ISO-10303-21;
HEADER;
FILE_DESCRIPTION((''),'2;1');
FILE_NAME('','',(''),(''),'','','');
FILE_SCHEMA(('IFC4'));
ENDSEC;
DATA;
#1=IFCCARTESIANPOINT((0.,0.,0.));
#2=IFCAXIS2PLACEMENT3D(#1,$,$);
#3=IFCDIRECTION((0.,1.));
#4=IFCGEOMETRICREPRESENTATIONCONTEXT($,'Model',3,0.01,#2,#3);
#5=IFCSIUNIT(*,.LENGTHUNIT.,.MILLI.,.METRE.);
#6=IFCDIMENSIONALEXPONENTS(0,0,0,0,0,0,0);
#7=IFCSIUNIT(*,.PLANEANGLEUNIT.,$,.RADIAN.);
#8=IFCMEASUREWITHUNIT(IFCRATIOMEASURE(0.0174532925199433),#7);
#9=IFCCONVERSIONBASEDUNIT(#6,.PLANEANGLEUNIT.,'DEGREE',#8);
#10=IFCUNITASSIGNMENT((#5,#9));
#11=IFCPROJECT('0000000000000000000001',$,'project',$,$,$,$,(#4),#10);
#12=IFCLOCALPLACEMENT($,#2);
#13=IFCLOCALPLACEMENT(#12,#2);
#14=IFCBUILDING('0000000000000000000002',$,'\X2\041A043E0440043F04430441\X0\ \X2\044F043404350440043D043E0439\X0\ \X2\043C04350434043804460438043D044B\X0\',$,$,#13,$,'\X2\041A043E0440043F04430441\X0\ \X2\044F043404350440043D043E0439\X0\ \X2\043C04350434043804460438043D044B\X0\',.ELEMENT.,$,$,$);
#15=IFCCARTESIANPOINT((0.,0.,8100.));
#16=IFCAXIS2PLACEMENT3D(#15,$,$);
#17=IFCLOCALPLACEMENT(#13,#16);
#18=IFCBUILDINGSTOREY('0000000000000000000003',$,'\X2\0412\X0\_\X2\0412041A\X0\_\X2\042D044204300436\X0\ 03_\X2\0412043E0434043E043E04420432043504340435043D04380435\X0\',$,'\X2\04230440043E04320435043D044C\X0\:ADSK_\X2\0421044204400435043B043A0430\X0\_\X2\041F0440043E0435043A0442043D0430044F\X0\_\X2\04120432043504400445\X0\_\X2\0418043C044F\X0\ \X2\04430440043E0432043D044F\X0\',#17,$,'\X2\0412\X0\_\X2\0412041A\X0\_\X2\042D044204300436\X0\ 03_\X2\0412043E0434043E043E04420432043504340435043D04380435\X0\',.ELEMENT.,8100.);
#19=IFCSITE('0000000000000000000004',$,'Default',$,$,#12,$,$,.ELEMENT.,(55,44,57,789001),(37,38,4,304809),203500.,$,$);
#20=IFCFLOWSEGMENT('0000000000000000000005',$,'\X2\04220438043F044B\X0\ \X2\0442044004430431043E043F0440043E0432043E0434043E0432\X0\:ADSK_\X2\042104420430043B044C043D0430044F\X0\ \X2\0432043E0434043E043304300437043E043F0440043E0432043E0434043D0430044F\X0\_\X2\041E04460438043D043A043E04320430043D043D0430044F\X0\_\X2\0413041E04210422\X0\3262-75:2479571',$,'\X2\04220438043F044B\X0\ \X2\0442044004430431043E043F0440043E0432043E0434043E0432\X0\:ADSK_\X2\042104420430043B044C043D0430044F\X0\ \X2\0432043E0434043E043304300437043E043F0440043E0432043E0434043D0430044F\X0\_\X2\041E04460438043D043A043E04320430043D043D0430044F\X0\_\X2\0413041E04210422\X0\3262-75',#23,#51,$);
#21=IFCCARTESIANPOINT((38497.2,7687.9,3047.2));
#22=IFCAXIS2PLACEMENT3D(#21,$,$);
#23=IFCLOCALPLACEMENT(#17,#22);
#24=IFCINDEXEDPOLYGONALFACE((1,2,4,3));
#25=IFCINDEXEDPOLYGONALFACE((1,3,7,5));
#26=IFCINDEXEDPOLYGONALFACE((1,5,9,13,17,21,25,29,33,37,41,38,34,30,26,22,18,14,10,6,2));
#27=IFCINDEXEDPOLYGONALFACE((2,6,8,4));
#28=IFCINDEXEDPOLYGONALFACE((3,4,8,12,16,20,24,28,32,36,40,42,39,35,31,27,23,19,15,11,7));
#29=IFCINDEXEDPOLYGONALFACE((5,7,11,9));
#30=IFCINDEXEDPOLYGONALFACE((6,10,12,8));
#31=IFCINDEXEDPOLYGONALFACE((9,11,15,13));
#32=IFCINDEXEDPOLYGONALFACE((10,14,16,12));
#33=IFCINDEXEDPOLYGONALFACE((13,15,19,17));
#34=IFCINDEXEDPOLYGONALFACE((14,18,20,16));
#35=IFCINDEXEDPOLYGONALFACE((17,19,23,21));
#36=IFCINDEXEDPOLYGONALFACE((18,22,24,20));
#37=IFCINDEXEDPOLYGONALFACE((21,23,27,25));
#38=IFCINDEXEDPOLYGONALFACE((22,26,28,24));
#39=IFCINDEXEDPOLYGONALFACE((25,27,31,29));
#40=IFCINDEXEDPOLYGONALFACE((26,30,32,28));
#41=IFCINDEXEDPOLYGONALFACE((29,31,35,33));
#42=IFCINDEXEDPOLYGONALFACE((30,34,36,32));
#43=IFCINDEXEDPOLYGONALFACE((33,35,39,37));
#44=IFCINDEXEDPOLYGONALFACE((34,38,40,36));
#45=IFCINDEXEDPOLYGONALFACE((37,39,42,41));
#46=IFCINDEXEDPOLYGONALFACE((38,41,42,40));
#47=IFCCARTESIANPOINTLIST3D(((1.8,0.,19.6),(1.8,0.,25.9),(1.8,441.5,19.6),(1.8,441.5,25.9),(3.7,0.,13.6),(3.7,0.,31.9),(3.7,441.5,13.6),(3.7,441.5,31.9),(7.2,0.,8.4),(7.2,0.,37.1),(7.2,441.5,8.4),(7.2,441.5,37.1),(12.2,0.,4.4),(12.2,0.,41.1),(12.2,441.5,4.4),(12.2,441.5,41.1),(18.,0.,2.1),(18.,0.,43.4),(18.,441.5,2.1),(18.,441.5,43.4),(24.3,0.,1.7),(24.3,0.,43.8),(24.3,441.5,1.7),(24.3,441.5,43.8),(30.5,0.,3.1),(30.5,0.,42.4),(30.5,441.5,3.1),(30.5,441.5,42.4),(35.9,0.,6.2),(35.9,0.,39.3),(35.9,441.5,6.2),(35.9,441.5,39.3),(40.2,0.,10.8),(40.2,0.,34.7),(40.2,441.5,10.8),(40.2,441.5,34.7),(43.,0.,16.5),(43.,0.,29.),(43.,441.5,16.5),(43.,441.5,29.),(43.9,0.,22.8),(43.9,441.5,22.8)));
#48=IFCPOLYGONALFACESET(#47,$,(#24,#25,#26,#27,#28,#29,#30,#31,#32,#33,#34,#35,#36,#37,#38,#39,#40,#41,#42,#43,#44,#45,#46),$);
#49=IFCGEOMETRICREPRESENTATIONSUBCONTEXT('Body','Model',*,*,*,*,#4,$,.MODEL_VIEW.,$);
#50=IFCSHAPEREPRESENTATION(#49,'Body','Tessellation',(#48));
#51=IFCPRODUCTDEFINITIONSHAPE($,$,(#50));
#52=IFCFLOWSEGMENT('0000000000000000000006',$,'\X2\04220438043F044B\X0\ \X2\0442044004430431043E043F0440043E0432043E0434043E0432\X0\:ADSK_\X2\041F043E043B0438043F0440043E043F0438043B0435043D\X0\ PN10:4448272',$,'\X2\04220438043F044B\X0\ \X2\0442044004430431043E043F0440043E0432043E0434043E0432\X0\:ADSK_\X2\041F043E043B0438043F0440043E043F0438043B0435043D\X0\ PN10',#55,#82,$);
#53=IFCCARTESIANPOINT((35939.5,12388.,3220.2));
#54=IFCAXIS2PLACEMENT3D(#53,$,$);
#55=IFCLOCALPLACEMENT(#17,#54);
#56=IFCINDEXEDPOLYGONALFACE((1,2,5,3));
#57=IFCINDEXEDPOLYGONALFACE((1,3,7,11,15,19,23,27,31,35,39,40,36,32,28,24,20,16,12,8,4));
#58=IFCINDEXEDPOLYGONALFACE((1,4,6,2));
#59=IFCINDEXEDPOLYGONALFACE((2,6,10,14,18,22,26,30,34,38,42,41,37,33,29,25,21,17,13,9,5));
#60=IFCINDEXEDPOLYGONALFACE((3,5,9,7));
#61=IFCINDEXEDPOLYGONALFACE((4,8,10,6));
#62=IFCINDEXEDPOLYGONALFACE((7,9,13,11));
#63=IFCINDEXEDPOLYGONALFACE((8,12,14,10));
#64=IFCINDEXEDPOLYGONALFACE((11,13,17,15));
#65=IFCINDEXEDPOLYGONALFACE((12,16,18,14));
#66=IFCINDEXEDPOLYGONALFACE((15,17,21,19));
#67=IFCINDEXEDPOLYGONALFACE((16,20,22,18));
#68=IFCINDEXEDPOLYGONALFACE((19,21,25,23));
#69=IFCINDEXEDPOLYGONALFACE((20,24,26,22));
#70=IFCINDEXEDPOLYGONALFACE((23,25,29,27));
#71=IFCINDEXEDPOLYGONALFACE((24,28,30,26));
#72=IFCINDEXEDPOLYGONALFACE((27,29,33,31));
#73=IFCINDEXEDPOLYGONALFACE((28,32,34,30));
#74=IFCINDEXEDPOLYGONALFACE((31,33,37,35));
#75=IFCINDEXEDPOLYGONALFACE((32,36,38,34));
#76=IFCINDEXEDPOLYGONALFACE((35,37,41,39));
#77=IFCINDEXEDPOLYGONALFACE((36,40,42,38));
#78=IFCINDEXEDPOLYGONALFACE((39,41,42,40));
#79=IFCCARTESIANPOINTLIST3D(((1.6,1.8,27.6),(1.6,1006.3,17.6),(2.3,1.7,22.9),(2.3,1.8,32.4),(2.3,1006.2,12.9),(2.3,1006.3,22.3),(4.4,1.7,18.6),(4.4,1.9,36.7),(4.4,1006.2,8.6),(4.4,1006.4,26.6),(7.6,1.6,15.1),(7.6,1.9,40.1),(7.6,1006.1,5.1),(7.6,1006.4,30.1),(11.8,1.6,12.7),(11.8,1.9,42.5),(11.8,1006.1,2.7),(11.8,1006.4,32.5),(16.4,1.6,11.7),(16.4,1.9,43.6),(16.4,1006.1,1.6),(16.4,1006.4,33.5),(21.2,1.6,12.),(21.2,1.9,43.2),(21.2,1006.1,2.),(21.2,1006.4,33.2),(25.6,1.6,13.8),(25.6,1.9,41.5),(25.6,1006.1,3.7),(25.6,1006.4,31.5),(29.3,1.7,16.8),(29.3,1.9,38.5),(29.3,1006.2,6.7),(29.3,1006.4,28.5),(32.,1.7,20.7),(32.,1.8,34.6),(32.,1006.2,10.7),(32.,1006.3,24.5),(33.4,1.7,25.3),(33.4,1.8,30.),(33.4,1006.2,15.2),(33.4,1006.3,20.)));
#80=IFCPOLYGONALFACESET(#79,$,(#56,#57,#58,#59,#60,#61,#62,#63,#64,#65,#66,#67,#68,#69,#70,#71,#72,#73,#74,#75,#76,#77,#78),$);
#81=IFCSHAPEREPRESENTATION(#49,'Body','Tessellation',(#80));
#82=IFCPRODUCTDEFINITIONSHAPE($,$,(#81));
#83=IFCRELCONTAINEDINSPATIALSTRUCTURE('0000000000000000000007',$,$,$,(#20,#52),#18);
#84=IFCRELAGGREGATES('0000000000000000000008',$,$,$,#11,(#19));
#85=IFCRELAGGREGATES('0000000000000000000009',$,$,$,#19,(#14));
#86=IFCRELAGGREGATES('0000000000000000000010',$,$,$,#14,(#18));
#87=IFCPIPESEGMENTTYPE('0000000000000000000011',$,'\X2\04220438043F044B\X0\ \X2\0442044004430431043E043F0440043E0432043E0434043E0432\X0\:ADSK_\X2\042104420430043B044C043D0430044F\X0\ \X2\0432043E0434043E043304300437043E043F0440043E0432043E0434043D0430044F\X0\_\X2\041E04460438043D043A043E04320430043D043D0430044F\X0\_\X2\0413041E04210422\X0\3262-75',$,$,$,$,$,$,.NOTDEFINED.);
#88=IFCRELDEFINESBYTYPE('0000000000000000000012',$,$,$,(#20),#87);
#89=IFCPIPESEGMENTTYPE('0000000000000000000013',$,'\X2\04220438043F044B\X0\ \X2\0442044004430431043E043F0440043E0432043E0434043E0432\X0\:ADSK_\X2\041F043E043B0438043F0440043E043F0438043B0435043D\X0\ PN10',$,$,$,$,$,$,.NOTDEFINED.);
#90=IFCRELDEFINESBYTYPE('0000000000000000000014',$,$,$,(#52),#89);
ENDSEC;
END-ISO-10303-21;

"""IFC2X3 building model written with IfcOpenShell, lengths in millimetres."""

from ifc_helpers import new_model, entity, si_unit, converted_unit, direction, frame, origin, origin_2d_with_axis, place, context, subcontext, project, spatial, circle, extrude, type_object, element, save


model = new_model("IFC2X3")

# Units and contexts
model_context = context("Model", 3, precision=0.01, world=origin(), true_north=direction((0.0, 1.0)))
body_context = subcontext(model_context, "Body", "Model", "MODEL_VIEW")
ifc_project = project(units=[si_unit("LENGTHUNIT", "METRE", prefix="MILLI"), converted_unit("PLANEANGLEUNIT", "DEGREE", entity("IfcRatioMeasure", 0.0174532925199433), si_unit("PLANEANGLEUNIT", "RADIAN"), dimensions=[0, 0, 0, 0, 0, 0, 0])], contexts=[model_context])

# Site, building, storey
site_placement = place(None, origin())
site = spatial("IfcSite", under=ifc_project, at=site_placement, Name="Default", CompositionType="ELEMENT", RefLatitude=(55, 44, 57, 789001), RefLongitude=(37, 38, 4, 304809), RefElevation=203500.0)
building_placement = place(site_placement, origin())
building = spatial("IfcBuilding", under=site, at=building_placement, Name="Корпус ядерной медицины", LongName="Корпус ядерной медицины", CompositionType="ELEMENT")
storey_placement = place(building_placement, frame((0.0, 0.0, 8100.0)))
storey = spatial("IfcBuildingStorey", under=building, at=storey_placement, Name="В_ВК_Этаж 03_Водоотведение", ObjectType="Уровень:ADSK_Стрелка_Проектная_Вверх_Имя уровня", LongName="В_ВК_Этаж 03_Водоотведение", CompositionType="ELEMENT", Elevation=8100.0)

# Flow segments
pipe_segment_type_1 = type_object("IfcPipeSegmentType", Name="Типы трубопроводов:ADSK_Стальная водогазопроводная_Оцинкованная_ГОСТ3262-75", PredefinedType="NOTDEFINED")
flow_segment_1_placement = place(storey_placement, frame((38497.2, 7687.9, 3047.2)))
element("IfcFlowSegment", 1, at=flow_segment_1_placement, inside=storey, type_object=pipe_segment_type_1, Name="Типы трубопроводов:ADSK_Стальная водогазопроводная_Оцинкованная_ГОСТ3262-75:2479571", ObjectType="Типы трубопроводов:ADSK_Стальная водогазопроводная_Оцинкованная_ГОСТ3262-75", context=body_context, shape_type="SweptSolid", body=[
    extrude(circle(Radius=21.1, at=origin_2d_with_axis()), frame((22.8, 0.0, 22.8), z_axis=(0.0, 1.0, 0.0), x_axis=(1.0, 0.0, 0.0)), (0.0, 0.0, 1.0), 441.5),
])
pipe_segment_type_2 = type_object("IfcPipeSegmentType", Name="Типы трубопроводов:ADSK_Полипропилен PN10", PredefinedType="NOTDEFINED")
flow_segment_2_placement = place(storey_placement, frame((35939.5, 12388.0, 3220.2)))
element("IfcFlowSegment", 2, at=flow_segment_2_placement, inside=storey, type_object=pipe_segment_type_2, Name="Типы трубопроводов:ADSK_Полипропилен PN10:4448272", ObjectType="Типы трубопроводов:ADSK_Полипропилен PN10", context=body_context, shape_type="SweptSolid", body=[
    extrude(circle(Radius=16.0, at=origin_2d_with_axis()), frame((17.6, 1.8, 27.6), z_axis=(0.0, 0.99995, -0.01), x_axis=(-1.0, 0.0, 0.0)), (0.0, 0.0, 1.0), 1004.6),
])

save(model, "model.ifc")
